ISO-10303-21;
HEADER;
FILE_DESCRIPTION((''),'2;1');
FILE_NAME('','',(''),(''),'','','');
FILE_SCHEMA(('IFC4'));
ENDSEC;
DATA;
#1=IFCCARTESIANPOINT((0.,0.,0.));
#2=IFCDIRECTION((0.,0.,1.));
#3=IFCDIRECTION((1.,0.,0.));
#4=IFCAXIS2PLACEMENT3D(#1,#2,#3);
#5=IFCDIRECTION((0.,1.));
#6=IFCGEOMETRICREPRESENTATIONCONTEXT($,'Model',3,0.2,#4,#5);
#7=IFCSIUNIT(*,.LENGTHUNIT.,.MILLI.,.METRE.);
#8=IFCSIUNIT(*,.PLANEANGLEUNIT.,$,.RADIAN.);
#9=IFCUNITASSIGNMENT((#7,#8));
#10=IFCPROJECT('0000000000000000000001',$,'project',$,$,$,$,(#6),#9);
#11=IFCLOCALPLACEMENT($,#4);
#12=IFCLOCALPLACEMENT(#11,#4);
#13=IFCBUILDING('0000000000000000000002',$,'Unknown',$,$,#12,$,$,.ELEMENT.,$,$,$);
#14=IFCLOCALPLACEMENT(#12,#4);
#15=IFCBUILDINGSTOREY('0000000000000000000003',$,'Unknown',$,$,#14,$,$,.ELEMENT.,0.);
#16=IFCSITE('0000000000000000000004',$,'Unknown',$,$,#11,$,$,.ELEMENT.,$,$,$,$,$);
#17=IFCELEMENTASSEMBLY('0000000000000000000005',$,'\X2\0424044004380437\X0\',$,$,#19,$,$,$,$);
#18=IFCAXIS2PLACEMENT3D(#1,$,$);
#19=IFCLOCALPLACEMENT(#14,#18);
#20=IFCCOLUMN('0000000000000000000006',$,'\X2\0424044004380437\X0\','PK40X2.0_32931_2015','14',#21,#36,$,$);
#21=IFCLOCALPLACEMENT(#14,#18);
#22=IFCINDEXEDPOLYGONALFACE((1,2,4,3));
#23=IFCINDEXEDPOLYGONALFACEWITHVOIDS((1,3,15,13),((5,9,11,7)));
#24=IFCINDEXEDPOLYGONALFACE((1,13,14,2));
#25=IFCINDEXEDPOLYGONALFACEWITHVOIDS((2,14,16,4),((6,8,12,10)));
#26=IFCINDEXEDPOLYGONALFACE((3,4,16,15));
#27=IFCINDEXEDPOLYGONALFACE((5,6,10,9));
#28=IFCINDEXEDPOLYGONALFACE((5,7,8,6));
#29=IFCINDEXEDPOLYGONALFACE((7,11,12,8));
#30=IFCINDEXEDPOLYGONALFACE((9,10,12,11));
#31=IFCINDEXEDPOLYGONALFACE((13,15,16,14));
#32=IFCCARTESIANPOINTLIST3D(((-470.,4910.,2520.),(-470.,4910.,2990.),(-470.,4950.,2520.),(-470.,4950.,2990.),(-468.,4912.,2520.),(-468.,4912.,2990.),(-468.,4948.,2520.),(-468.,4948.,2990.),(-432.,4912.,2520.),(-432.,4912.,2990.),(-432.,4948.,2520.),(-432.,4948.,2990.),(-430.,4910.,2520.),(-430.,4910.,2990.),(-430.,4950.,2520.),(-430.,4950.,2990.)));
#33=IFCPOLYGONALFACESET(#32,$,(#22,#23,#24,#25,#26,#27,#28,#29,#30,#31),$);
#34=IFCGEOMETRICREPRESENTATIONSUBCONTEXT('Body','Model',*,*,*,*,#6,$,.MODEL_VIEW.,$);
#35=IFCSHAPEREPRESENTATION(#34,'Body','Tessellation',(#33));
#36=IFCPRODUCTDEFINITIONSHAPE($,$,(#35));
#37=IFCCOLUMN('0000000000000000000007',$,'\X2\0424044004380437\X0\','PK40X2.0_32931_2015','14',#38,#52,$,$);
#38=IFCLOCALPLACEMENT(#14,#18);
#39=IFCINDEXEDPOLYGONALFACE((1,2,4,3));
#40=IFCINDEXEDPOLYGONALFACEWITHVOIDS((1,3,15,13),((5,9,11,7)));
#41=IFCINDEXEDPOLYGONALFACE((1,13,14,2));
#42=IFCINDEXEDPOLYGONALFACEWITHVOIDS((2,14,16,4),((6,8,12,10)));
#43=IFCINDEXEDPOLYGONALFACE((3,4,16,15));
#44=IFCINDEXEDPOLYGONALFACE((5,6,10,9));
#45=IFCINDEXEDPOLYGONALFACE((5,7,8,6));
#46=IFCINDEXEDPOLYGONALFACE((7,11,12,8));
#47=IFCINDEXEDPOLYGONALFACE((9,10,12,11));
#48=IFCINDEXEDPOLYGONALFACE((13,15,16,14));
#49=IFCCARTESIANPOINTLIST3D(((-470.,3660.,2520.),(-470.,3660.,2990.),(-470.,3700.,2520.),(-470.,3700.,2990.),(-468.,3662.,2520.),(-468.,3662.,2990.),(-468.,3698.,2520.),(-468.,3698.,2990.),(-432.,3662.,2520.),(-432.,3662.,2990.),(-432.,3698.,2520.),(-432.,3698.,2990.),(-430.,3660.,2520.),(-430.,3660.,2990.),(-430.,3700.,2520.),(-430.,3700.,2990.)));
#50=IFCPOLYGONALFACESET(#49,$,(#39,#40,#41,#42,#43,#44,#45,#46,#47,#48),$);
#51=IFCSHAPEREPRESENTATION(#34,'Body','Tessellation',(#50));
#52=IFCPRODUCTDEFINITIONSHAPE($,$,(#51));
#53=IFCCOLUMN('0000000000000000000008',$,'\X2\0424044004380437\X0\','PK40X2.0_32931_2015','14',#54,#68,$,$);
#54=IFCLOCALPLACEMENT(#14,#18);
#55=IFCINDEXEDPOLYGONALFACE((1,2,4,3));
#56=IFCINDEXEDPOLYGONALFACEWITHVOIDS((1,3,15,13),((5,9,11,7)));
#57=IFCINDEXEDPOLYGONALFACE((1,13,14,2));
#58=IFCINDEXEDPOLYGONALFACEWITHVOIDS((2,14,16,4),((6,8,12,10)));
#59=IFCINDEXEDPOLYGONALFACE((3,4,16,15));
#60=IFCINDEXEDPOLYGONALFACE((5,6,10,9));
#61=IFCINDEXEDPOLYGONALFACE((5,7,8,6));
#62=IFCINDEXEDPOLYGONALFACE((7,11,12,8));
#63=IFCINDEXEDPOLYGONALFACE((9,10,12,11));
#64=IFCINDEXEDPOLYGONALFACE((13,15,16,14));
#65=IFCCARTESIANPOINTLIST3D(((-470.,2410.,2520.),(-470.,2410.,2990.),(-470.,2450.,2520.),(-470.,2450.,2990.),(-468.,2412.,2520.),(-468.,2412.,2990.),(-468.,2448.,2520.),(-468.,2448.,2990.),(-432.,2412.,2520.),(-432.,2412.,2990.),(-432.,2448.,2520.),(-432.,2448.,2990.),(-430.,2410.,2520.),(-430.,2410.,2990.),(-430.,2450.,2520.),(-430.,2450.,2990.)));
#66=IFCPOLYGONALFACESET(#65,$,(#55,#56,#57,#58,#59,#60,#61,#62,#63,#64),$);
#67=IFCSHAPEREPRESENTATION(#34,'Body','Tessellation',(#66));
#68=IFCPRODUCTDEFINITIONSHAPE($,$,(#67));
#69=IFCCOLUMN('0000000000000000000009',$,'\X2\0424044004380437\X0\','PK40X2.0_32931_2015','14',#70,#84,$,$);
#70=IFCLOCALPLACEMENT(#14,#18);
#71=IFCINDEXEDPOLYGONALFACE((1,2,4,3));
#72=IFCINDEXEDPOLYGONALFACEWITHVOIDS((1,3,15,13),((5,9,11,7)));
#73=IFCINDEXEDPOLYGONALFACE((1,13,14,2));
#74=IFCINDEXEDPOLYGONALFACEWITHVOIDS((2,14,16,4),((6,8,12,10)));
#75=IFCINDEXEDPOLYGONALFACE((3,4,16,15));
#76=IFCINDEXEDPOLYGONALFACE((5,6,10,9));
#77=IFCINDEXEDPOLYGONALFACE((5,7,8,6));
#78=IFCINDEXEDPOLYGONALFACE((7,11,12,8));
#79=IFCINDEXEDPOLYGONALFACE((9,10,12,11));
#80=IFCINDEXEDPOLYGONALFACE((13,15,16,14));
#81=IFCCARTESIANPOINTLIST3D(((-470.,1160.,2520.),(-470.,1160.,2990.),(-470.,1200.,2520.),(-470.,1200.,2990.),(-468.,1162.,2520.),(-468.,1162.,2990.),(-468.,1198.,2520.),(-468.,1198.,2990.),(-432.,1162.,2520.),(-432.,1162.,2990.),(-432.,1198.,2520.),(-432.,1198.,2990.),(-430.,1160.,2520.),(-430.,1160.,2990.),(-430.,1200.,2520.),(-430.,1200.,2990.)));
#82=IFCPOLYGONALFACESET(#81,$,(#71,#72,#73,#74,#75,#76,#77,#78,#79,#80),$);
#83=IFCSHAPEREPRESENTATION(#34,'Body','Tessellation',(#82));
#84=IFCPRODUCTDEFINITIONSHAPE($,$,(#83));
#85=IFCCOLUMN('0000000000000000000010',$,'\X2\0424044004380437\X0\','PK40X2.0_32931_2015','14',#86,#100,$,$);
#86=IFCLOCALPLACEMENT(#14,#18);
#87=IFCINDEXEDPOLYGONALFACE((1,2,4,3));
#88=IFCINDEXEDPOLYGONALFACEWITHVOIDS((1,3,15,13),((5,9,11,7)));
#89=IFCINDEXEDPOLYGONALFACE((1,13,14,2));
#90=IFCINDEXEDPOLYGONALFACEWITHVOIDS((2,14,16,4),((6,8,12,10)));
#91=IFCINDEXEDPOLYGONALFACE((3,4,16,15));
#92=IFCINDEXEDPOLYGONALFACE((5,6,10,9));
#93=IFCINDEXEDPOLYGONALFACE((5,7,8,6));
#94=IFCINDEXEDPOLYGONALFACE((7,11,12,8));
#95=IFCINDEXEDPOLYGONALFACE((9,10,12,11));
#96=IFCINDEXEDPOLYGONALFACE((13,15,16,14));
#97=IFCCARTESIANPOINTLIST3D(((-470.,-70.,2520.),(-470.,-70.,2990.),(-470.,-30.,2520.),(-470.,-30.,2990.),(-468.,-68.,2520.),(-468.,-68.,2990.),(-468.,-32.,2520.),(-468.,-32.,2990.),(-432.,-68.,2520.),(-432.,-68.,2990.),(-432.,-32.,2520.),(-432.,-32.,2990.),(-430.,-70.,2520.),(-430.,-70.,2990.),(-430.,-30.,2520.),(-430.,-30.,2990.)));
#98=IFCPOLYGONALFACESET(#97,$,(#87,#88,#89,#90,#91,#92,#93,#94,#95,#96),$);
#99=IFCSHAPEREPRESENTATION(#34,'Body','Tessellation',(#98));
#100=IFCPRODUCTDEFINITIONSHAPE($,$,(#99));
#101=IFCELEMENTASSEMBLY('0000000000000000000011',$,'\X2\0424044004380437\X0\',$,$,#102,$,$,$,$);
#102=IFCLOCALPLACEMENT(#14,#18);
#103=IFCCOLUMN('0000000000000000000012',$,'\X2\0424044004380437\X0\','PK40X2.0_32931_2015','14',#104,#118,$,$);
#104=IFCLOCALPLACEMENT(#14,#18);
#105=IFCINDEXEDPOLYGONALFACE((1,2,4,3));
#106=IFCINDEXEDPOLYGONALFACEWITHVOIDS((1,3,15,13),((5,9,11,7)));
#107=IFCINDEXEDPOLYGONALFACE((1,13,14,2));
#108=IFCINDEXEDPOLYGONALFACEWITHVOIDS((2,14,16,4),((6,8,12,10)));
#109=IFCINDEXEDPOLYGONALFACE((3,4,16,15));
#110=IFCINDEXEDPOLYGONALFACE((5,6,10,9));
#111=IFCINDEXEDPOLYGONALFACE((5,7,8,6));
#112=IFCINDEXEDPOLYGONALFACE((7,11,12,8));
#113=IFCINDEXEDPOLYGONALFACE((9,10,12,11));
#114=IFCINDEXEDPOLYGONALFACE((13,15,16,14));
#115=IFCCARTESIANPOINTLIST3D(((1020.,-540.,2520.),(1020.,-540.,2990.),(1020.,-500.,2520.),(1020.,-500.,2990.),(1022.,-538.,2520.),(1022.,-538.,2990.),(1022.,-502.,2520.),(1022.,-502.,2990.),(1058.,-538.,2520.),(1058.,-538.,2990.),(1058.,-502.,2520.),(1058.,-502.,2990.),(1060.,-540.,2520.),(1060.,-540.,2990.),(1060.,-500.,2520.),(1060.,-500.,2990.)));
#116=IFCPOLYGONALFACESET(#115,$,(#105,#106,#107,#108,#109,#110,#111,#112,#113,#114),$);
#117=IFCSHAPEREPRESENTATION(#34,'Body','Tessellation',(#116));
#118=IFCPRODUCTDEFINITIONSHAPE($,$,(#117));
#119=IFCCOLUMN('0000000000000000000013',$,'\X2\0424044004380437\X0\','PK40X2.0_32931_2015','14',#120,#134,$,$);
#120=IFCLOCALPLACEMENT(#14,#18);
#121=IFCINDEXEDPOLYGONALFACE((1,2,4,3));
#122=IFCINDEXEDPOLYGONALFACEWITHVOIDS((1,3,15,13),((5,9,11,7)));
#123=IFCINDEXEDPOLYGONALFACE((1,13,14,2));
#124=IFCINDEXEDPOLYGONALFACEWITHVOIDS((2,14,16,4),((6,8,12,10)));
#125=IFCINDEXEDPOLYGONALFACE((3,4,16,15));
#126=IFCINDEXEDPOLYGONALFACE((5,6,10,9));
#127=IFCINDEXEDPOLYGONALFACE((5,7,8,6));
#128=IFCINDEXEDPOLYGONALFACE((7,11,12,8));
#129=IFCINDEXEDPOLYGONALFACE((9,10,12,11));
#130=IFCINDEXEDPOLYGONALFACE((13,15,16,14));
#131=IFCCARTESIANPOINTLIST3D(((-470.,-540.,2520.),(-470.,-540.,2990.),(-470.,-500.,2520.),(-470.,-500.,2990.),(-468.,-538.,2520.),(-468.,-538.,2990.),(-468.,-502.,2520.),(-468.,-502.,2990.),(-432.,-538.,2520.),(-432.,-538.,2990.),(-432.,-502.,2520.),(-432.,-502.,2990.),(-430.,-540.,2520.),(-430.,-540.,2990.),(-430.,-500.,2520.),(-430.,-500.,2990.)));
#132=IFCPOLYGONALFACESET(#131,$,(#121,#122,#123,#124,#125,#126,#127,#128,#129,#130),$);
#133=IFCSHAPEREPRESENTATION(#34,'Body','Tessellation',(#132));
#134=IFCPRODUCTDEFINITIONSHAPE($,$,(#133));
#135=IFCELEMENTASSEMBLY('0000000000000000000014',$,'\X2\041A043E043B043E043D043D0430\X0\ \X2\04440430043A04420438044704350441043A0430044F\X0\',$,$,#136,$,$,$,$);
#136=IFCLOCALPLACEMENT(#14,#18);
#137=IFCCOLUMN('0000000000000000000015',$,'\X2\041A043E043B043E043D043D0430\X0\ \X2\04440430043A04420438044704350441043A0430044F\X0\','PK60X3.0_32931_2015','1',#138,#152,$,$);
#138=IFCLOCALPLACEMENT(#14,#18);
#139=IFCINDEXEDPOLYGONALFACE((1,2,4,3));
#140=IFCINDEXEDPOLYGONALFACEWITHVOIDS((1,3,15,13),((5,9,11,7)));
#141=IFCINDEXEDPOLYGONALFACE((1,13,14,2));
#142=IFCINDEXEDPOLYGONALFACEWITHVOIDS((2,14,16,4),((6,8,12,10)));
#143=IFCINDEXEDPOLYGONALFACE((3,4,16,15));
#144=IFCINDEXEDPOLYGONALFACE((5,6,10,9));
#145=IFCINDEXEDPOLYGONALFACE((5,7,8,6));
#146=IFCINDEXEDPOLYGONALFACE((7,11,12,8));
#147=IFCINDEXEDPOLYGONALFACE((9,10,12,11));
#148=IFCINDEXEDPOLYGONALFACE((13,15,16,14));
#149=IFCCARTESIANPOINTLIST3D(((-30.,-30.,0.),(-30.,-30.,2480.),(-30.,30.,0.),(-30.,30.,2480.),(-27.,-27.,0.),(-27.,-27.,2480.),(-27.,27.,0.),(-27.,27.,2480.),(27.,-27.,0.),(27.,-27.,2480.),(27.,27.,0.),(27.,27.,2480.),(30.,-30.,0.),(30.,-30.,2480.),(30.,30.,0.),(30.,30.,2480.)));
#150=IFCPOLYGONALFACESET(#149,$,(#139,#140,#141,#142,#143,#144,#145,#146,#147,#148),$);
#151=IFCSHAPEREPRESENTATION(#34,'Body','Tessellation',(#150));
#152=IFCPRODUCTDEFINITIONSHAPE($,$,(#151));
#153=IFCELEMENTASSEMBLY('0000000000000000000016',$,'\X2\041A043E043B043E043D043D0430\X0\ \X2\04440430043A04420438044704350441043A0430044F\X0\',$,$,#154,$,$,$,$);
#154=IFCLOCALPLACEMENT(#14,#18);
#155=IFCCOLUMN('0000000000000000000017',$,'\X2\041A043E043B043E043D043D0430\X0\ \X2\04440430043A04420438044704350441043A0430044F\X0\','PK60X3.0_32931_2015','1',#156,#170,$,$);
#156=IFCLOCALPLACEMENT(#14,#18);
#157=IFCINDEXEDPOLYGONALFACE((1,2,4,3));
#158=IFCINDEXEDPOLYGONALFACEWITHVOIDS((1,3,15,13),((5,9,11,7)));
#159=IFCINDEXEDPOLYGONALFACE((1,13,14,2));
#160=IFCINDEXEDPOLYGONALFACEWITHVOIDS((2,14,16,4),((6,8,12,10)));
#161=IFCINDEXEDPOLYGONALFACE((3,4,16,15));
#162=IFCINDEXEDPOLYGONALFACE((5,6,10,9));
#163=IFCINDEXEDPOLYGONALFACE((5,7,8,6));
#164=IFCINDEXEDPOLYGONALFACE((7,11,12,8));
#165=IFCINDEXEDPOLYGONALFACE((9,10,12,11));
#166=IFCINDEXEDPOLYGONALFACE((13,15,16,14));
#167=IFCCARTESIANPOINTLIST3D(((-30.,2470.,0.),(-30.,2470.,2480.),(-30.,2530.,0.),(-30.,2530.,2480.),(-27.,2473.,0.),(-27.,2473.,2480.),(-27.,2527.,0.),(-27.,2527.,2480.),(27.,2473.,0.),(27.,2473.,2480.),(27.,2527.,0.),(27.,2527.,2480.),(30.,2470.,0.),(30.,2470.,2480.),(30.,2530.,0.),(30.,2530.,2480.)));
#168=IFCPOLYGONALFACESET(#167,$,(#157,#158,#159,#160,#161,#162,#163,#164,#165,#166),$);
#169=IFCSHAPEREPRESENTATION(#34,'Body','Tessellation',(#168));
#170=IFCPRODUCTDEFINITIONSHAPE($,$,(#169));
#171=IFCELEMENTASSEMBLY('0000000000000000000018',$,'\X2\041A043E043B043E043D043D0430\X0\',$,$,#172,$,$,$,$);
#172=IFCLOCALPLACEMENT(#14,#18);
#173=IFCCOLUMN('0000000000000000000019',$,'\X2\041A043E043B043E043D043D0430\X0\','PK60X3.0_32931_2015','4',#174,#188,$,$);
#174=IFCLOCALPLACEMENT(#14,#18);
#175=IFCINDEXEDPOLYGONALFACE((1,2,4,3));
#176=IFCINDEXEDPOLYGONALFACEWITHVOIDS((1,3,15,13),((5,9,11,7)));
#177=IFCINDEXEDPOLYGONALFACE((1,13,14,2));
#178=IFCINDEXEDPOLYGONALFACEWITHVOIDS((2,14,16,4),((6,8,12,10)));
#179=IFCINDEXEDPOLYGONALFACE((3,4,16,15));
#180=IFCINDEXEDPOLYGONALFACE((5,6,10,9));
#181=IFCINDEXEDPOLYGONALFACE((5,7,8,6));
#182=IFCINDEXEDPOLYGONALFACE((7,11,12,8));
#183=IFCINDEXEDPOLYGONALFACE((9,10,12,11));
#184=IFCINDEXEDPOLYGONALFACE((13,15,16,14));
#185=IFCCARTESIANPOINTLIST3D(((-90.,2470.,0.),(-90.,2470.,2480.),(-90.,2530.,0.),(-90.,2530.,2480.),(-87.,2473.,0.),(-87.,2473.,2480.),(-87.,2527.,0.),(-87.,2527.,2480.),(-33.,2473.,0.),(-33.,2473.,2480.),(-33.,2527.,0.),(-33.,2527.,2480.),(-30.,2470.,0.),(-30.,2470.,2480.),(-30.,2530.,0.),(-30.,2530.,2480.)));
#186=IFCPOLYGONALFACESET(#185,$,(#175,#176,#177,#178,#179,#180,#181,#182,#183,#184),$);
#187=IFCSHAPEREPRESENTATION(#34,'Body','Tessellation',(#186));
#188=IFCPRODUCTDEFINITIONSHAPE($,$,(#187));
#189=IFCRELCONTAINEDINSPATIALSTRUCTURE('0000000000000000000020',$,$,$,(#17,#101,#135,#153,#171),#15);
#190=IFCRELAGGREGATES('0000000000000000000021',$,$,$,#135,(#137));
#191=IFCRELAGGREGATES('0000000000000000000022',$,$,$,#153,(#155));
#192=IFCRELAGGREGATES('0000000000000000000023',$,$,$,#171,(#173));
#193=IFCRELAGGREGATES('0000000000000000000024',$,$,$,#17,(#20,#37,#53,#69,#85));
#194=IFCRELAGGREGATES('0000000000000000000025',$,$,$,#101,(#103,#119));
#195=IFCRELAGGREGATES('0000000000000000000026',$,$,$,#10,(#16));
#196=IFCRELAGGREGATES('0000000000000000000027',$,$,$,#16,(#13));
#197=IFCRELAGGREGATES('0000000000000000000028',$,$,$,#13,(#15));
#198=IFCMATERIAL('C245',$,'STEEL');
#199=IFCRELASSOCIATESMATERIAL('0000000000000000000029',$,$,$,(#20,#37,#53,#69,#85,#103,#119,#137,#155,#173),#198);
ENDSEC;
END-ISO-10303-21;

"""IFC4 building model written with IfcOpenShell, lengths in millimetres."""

from ifc_helpers import new_model, si_unit, direction, frame, origin_with_axes, place, context, subcontext, project, spatial, line, indexed_curve, outline, extrude, material, element, aggregate, save


model = new_model("IFC4")

# Units and contexts
model_context = context("Model", 3, precision=0.2, world=origin_with_axes(), true_north=direction((0.0, 1.0)))
body_context = subcontext(model_context, "Body", "Model", "MODEL_VIEW")
ifc_project = project(units=[si_unit("LENGTHUNIT", "METRE", prefix="MILLI"), si_unit("PLANEANGLEUNIT", "RADIAN")], contexts=[model_context])

# Site, building, storey
site_placement = place(None, origin_with_axes())
site = spatial("IfcSite", under=ifc_project, at=site_placement, Name="Unknown", CompositionType="ELEMENT")
building_placement = place(site_placement, origin_with_axes())
building = spatial("IfcBuilding", under=site, at=building_placement, Name="Unknown", CompositionType="ELEMENT")
storey_placement = place(building_placement, origin_with_axes())
storey = spatial("IfcBuildingStorey", under=building, at=storey_placement, Name="Unknown", CompositionType="ELEMENT", Elevation=0.0)

# Element assemblies, columns
assembly_1_placement = place(storey_placement, frame((-450.0, -500.0, 3010.0), z_axis=(1.0, 0.0, 0.0), x_axis=(0.0, 1.0, 0.0)))
assembly_1 = element("IfcElementAssembly", 1, at=assembly_1_placement, inside=storey, Name="Фриз")
ifc_material = material(Name="C245", Category="STEEL")
column_1_placement = place(assembly_1_placement, frame((5430.0, -490.0, 0.0), z_axis=(1.0, 0.0, 0.0), x_axis=(0.0, 1.0, 0.0)))
column_1 = element("IfcColumn", 2, at=column_1_placement, material=ifc_material, Name="Фриз", Description="PK40X2.0_32931_2015", ObjectType="14", context=body_context, shape_type="SolidModel", body=[
    extrude(outline(indexed_curve([(-20.0, -20.0), (20.0, -20.0), (20.0, 20.0), (-20.0, 20.0)], segments=[line(1, 2, 3, 4, 1)]), holes=[indexed_curve([(-18.0, -18.0), (-18.0, 18.0), (18.0, 18.0), (18.0, -18.0)], segments=[line(1, 2, 3, 4, 1)])]), frame((0.0, 0.0, 0.0), z_axis=(-1.0, 0.0, 0.0), x_axis=(0.0, 0.0, 1.0)), (0.0, 0.0, -1.0), 470.0),
])
column_2_placement = place(assembly_1_placement, frame((4180.0, -490.0, 0.0), z_axis=(1.0, 0.0, 0.0), x_axis=(0.0, 1.0, 0.0)))
column_2 = element("IfcColumn", 3, at=column_2_placement, material=ifc_material, Name="Фриз", Description="PK40X2.0_32931_2015", ObjectType="14", context=body_context, shape_type="SolidModel", body=[
    extrude(outline(indexed_curve([(-20.0, -20.0), (20.0, -20.0), (20.0, 20.0), (-20.0, 20.0)], segments=[line(1, 2, 3, 4, 1)]), holes=[indexed_curve([(-18.0, -18.0), (-18.0, 18.0), (18.0, 18.0), (18.0, -18.0)], segments=[line(1, 2, 3, 4, 1)])]), frame((0.0, 0.0, 0.0), z_axis=(-1.0, 0.0, 0.0), x_axis=(0.0, 0.0, 1.0)), (0.0, 0.0, -1.0), 470.0),
])
column_3_placement = place(assembly_1_placement, frame((2930.0, -490.0, 0.0), z_axis=(1.0, 0.0, 0.0), x_axis=(0.0, 1.0, 0.0)))
column_3 = element("IfcColumn", 4, at=column_3_placement, material=ifc_material, Name="Фриз", Description="PK40X2.0_32931_2015", ObjectType="14", context=body_context, shape_type="SolidModel", body=[
    extrude(outline(indexed_curve([(-20.0, -20.0), (20.0, -20.0), (20.0, 20.0), (-20.0, 20.0)], segments=[line(1, 2, 3, 4, 1)]), holes=[indexed_curve([(-18.0, -18.0), (-18.0, 18.0), (18.0, 18.0), (18.0, -18.0)], segments=[line(1, 2, 3, 4, 1)])]), frame((0.0, 0.0, 0.0), z_axis=(-1.0, 0.0, 0.0), x_axis=(0.0, 0.0, 1.0)), (0.0, 0.0, -1.0), 470.0),
])
column_4_placement = place(assembly_1_placement, frame((1680.0, -490.0, 0.0), z_axis=(1.0, 0.0, 0.0), x_axis=(0.0, 1.0, 0.0)))
column_4 = element("IfcColumn", 5, at=column_4_placement, material=ifc_material, Name="Фриз", Description="PK40X2.0_32931_2015", ObjectType="14", context=body_context, shape_type="SolidModel", body=[
    extrude(outline(indexed_curve([(-20.0, -20.0), (20.0, -20.0), (20.0, 20.0), (-20.0, 20.0)], segments=[line(1, 2, 3, 4, 1)]), holes=[indexed_curve([(-18.0, -18.0), (-18.0, 18.0), (18.0, 18.0), (18.0, -18.0)], segments=[line(1, 2, 3, 4, 1)])]), frame((0.0, 0.0, 0.0), z_axis=(-1.0, 0.0, 0.0), x_axis=(0.0, 0.0, 1.0)), (0.0, 0.0, -1.0), 470.0),
])
column_5_placement = place(assembly_1_placement, frame((450.0, -490.0, 0.0), z_axis=(1.0, 0.0, 0.0), x_axis=(0.0, 1.0, 0.0)))
column_5 = element("IfcColumn", 6, at=column_5_placement, material=ifc_material, Name="Фриз", Description="PK40X2.0_32931_2015", ObjectType="14", context=body_context, shape_type="SolidModel", body=[
    extrude(outline(indexed_curve([(-20.0, -20.0), (20.0, -20.0), (20.0, 20.0), (-20.0, 20.0)], segments=[line(1, 2, 3, 4, 1)]), holes=[indexed_curve([(-18.0, -18.0), (-18.0, 18.0), (18.0, 18.0), (18.0, -18.0)], segments=[line(1, 2, 3, 4, 1)])]), frame((0.0, 0.0, 0.0), z_axis=(-1.0, 0.0, 0.0), x_axis=(0.0, 0.0, 1.0)), (0.0, 0.0, -1.0), 470.0),
])
assembly_2_placement = place(storey_placement, frame((-470.0, -520.0, 3010.0), z_axis=(0.0, -1.0, 0.0), x_axis=(1.0, 0.0, 0.0)))
assembly_2 = element("IfcElementAssembly", 7, at=assembly_2_placement, inside=storey, Name="Фриз")
column_6_placement = place(assembly_2_placement, frame((1510.0, -490.0, 0.0), z_axis=(0.0, 0.0, -1.0), x_axis=(0.0, 1.0, 0.0)))
column_6 = element("IfcColumn", 8, at=column_6_placement, material=ifc_material, Name="Фриз", Description="PK40X2.0_32931_2015", ObjectType="14", context=body_context, shape_type="SolidModel", body=[
    extrude(outline(indexed_curve([(-20.0, -20.0), (20.0, -20.0), (20.0, 20.0), (-20.0, 20.0)], segments=[line(1, 2, 3, 4, 1)]), holes=[indexed_curve([(-18.0, -18.0), (-18.0, 18.0), (18.0, 18.0), (18.0, -18.0)], segments=[line(1, 2, 3, 4, 1)])]), frame((0.0, 0.0, 0.0), z_axis=(-1.0, 0.0, 0.0), x_axis=(0.0, 0.0, 1.0)), (0.0, 0.0, -1.0), 470.0),
])
column_7_placement = place(assembly_2_placement, frame((20.0, -490.0, 0.0), z_axis=(0.0, 0.0, -1.0), x_axis=(0.0, 1.0, 0.0)))
column_7 = element("IfcColumn", 9, at=column_7_placement, material=ifc_material, Name="Фриз", Description="PK40X2.0_32931_2015", ObjectType="14", context=body_context, shape_type="SolidModel", body=[
    extrude(outline(indexed_curve([(-20.0, -20.0), (20.0, -20.0), (20.0, 20.0), (-20.0, 20.0)], segments=[line(1, 2, 3, 4, 1)]), holes=[indexed_curve([(-18.0, -18.0), (-18.0, 18.0), (18.0, 18.0), (18.0, -18.0)], segments=[line(1, 2, 3, 4, 1)])]), frame((0.0, 0.0, 0.0), z_axis=(-1.0, 0.0, 0.0), x_axis=(0.0, 0.0, 1.0)), (0.0, 0.0, -1.0), 470.0),
])

# Element assemblies, columns
assembly_3_placement = place(storey_placement, frame((0.0, 0.0, 0.0), z_axis=(-1.0, 0.0, 0.0), x_axis=(0.0, 0.0, 1.0)))
assembly_3 = element("IfcElementAssembly", 10, at=assembly_3_placement, inside=storey, Name="Колонна фактическая")
column_8_placement = place(assembly_3_placement, origin_with_axes())
column_8 = element("IfcColumn", 11, at=column_8_placement, material=ifc_material, Name="Колонна фактическая", Description="PK60X3.0_32931_2015", ObjectType="1", context=body_context, shape_type="SolidModel", body=[
    extrude(outline(indexed_curve([(-30.0, -30.0), (30.0, -30.0), (30.0, 30.0), (-30.0, 30.0)], segments=[line(1, 2, 3, 4, 1)]), holes=[indexed_curve([(-27.0, -27.0), (-27.0, 27.0), (27.0, 27.0), (27.0, -27.0)], segments=[line(1, 2, 3, 4, 1)])]), frame((0.0, 0.0, 0.0), z_axis=(-1.0, 0.0, 0.0), x_axis=(0.0, 0.0, 1.0)), (0.0, 0.0, -1.0), 2480.0),
])
aggregate(assembly_3, [column_8])
assembly_4_placement = place(storey_placement, frame((0.0, 2500.0, 0.0), z_axis=(-1.0, 0.0, 0.0), x_axis=(0.0, 0.0, 1.0)))
assembly_4 = element("IfcElementAssembly", 12, at=assembly_4_placement, inside=storey, Name="Колонна фактическая")
column_9_placement = place(assembly_4_placement, origin_with_axes())
column_9 = element("IfcColumn", 13, at=column_9_placement, material=ifc_material, Name="Колонна фактическая", Description="PK60X3.0_32931_2015", ObjectType="1", context=body_context, shape_type="SolidModel", body=[
    extrude(outline(indexed_curve([(-30.0, -30.0), (30.0, -30.0), (30.0, 30.0), (-30.0, 30.0)], segments=[line(1, 2, 3, 4, 1)]), holes=[indexed_curve([(-27.0, -27.0), (-27.0, 27.0), (27.0, 27.0), (27.0, -27.0)], segments=[line(1, 2, 3, 4, 1)])]), frame((0.0, 0.0, 0.0), z_axis=(-1.0, 0.0, 0.0), x_axis=(0.0, 0.0, 1.0)), (0.0, 0.0, -1.0), 2480.0),
])
aggregate(assembly_4, [column_9])
assembly_5_placement = place(storey_placement, frame((-60.0, 2500.0, 0.0), z_axis=(-1.0, 0.0, 0.0), x_axis=(0.0, 0.0, 1.0)))
assembly_5 = element("IfcElementAssembly", 14, at=assembly_5_placement, inside=storey, Name="Колонна")
column_10_placement = place(assembly_5_placement, origin_with_axes())
column_10 = element("IfcColumn", 15, at=column_10_placement, material=ifc_material, Name="Колонна", Description="PK60X3.0_32931_2015", ObjectType="4", context=body_context, shape_type="SolidModel", body=[
    extrude(outline(indexed_curve([(-30.0, -30.0), (30.0, -30.0), (30.0, 30.0), (-30.0, 30.0)], segments=[line(1, 2, 3, 4, 1)]), holes=[indexed_curve([(-27.0, -27.0), (-27.0, 27.0), (27.0, 27.0), (27.0, -27.0)], segments=[line(1, 2, 3, 4, 1)])]), frame((0.0, 0.0, 0.0), z_axis=(-1.0, 0.0, 0.0), x_axis=(0.0, 0.0, 1.0)), (0.0, 0.0, -1.0), 2480.0),
])
aggregate(assembly_5, [column_10])

aggregate(assembly_1, [column_1, column_2, column_3, column_4, column_5])
aggregate(assembly_2, [column_6, column_7])

save(model, "model.ifc")
